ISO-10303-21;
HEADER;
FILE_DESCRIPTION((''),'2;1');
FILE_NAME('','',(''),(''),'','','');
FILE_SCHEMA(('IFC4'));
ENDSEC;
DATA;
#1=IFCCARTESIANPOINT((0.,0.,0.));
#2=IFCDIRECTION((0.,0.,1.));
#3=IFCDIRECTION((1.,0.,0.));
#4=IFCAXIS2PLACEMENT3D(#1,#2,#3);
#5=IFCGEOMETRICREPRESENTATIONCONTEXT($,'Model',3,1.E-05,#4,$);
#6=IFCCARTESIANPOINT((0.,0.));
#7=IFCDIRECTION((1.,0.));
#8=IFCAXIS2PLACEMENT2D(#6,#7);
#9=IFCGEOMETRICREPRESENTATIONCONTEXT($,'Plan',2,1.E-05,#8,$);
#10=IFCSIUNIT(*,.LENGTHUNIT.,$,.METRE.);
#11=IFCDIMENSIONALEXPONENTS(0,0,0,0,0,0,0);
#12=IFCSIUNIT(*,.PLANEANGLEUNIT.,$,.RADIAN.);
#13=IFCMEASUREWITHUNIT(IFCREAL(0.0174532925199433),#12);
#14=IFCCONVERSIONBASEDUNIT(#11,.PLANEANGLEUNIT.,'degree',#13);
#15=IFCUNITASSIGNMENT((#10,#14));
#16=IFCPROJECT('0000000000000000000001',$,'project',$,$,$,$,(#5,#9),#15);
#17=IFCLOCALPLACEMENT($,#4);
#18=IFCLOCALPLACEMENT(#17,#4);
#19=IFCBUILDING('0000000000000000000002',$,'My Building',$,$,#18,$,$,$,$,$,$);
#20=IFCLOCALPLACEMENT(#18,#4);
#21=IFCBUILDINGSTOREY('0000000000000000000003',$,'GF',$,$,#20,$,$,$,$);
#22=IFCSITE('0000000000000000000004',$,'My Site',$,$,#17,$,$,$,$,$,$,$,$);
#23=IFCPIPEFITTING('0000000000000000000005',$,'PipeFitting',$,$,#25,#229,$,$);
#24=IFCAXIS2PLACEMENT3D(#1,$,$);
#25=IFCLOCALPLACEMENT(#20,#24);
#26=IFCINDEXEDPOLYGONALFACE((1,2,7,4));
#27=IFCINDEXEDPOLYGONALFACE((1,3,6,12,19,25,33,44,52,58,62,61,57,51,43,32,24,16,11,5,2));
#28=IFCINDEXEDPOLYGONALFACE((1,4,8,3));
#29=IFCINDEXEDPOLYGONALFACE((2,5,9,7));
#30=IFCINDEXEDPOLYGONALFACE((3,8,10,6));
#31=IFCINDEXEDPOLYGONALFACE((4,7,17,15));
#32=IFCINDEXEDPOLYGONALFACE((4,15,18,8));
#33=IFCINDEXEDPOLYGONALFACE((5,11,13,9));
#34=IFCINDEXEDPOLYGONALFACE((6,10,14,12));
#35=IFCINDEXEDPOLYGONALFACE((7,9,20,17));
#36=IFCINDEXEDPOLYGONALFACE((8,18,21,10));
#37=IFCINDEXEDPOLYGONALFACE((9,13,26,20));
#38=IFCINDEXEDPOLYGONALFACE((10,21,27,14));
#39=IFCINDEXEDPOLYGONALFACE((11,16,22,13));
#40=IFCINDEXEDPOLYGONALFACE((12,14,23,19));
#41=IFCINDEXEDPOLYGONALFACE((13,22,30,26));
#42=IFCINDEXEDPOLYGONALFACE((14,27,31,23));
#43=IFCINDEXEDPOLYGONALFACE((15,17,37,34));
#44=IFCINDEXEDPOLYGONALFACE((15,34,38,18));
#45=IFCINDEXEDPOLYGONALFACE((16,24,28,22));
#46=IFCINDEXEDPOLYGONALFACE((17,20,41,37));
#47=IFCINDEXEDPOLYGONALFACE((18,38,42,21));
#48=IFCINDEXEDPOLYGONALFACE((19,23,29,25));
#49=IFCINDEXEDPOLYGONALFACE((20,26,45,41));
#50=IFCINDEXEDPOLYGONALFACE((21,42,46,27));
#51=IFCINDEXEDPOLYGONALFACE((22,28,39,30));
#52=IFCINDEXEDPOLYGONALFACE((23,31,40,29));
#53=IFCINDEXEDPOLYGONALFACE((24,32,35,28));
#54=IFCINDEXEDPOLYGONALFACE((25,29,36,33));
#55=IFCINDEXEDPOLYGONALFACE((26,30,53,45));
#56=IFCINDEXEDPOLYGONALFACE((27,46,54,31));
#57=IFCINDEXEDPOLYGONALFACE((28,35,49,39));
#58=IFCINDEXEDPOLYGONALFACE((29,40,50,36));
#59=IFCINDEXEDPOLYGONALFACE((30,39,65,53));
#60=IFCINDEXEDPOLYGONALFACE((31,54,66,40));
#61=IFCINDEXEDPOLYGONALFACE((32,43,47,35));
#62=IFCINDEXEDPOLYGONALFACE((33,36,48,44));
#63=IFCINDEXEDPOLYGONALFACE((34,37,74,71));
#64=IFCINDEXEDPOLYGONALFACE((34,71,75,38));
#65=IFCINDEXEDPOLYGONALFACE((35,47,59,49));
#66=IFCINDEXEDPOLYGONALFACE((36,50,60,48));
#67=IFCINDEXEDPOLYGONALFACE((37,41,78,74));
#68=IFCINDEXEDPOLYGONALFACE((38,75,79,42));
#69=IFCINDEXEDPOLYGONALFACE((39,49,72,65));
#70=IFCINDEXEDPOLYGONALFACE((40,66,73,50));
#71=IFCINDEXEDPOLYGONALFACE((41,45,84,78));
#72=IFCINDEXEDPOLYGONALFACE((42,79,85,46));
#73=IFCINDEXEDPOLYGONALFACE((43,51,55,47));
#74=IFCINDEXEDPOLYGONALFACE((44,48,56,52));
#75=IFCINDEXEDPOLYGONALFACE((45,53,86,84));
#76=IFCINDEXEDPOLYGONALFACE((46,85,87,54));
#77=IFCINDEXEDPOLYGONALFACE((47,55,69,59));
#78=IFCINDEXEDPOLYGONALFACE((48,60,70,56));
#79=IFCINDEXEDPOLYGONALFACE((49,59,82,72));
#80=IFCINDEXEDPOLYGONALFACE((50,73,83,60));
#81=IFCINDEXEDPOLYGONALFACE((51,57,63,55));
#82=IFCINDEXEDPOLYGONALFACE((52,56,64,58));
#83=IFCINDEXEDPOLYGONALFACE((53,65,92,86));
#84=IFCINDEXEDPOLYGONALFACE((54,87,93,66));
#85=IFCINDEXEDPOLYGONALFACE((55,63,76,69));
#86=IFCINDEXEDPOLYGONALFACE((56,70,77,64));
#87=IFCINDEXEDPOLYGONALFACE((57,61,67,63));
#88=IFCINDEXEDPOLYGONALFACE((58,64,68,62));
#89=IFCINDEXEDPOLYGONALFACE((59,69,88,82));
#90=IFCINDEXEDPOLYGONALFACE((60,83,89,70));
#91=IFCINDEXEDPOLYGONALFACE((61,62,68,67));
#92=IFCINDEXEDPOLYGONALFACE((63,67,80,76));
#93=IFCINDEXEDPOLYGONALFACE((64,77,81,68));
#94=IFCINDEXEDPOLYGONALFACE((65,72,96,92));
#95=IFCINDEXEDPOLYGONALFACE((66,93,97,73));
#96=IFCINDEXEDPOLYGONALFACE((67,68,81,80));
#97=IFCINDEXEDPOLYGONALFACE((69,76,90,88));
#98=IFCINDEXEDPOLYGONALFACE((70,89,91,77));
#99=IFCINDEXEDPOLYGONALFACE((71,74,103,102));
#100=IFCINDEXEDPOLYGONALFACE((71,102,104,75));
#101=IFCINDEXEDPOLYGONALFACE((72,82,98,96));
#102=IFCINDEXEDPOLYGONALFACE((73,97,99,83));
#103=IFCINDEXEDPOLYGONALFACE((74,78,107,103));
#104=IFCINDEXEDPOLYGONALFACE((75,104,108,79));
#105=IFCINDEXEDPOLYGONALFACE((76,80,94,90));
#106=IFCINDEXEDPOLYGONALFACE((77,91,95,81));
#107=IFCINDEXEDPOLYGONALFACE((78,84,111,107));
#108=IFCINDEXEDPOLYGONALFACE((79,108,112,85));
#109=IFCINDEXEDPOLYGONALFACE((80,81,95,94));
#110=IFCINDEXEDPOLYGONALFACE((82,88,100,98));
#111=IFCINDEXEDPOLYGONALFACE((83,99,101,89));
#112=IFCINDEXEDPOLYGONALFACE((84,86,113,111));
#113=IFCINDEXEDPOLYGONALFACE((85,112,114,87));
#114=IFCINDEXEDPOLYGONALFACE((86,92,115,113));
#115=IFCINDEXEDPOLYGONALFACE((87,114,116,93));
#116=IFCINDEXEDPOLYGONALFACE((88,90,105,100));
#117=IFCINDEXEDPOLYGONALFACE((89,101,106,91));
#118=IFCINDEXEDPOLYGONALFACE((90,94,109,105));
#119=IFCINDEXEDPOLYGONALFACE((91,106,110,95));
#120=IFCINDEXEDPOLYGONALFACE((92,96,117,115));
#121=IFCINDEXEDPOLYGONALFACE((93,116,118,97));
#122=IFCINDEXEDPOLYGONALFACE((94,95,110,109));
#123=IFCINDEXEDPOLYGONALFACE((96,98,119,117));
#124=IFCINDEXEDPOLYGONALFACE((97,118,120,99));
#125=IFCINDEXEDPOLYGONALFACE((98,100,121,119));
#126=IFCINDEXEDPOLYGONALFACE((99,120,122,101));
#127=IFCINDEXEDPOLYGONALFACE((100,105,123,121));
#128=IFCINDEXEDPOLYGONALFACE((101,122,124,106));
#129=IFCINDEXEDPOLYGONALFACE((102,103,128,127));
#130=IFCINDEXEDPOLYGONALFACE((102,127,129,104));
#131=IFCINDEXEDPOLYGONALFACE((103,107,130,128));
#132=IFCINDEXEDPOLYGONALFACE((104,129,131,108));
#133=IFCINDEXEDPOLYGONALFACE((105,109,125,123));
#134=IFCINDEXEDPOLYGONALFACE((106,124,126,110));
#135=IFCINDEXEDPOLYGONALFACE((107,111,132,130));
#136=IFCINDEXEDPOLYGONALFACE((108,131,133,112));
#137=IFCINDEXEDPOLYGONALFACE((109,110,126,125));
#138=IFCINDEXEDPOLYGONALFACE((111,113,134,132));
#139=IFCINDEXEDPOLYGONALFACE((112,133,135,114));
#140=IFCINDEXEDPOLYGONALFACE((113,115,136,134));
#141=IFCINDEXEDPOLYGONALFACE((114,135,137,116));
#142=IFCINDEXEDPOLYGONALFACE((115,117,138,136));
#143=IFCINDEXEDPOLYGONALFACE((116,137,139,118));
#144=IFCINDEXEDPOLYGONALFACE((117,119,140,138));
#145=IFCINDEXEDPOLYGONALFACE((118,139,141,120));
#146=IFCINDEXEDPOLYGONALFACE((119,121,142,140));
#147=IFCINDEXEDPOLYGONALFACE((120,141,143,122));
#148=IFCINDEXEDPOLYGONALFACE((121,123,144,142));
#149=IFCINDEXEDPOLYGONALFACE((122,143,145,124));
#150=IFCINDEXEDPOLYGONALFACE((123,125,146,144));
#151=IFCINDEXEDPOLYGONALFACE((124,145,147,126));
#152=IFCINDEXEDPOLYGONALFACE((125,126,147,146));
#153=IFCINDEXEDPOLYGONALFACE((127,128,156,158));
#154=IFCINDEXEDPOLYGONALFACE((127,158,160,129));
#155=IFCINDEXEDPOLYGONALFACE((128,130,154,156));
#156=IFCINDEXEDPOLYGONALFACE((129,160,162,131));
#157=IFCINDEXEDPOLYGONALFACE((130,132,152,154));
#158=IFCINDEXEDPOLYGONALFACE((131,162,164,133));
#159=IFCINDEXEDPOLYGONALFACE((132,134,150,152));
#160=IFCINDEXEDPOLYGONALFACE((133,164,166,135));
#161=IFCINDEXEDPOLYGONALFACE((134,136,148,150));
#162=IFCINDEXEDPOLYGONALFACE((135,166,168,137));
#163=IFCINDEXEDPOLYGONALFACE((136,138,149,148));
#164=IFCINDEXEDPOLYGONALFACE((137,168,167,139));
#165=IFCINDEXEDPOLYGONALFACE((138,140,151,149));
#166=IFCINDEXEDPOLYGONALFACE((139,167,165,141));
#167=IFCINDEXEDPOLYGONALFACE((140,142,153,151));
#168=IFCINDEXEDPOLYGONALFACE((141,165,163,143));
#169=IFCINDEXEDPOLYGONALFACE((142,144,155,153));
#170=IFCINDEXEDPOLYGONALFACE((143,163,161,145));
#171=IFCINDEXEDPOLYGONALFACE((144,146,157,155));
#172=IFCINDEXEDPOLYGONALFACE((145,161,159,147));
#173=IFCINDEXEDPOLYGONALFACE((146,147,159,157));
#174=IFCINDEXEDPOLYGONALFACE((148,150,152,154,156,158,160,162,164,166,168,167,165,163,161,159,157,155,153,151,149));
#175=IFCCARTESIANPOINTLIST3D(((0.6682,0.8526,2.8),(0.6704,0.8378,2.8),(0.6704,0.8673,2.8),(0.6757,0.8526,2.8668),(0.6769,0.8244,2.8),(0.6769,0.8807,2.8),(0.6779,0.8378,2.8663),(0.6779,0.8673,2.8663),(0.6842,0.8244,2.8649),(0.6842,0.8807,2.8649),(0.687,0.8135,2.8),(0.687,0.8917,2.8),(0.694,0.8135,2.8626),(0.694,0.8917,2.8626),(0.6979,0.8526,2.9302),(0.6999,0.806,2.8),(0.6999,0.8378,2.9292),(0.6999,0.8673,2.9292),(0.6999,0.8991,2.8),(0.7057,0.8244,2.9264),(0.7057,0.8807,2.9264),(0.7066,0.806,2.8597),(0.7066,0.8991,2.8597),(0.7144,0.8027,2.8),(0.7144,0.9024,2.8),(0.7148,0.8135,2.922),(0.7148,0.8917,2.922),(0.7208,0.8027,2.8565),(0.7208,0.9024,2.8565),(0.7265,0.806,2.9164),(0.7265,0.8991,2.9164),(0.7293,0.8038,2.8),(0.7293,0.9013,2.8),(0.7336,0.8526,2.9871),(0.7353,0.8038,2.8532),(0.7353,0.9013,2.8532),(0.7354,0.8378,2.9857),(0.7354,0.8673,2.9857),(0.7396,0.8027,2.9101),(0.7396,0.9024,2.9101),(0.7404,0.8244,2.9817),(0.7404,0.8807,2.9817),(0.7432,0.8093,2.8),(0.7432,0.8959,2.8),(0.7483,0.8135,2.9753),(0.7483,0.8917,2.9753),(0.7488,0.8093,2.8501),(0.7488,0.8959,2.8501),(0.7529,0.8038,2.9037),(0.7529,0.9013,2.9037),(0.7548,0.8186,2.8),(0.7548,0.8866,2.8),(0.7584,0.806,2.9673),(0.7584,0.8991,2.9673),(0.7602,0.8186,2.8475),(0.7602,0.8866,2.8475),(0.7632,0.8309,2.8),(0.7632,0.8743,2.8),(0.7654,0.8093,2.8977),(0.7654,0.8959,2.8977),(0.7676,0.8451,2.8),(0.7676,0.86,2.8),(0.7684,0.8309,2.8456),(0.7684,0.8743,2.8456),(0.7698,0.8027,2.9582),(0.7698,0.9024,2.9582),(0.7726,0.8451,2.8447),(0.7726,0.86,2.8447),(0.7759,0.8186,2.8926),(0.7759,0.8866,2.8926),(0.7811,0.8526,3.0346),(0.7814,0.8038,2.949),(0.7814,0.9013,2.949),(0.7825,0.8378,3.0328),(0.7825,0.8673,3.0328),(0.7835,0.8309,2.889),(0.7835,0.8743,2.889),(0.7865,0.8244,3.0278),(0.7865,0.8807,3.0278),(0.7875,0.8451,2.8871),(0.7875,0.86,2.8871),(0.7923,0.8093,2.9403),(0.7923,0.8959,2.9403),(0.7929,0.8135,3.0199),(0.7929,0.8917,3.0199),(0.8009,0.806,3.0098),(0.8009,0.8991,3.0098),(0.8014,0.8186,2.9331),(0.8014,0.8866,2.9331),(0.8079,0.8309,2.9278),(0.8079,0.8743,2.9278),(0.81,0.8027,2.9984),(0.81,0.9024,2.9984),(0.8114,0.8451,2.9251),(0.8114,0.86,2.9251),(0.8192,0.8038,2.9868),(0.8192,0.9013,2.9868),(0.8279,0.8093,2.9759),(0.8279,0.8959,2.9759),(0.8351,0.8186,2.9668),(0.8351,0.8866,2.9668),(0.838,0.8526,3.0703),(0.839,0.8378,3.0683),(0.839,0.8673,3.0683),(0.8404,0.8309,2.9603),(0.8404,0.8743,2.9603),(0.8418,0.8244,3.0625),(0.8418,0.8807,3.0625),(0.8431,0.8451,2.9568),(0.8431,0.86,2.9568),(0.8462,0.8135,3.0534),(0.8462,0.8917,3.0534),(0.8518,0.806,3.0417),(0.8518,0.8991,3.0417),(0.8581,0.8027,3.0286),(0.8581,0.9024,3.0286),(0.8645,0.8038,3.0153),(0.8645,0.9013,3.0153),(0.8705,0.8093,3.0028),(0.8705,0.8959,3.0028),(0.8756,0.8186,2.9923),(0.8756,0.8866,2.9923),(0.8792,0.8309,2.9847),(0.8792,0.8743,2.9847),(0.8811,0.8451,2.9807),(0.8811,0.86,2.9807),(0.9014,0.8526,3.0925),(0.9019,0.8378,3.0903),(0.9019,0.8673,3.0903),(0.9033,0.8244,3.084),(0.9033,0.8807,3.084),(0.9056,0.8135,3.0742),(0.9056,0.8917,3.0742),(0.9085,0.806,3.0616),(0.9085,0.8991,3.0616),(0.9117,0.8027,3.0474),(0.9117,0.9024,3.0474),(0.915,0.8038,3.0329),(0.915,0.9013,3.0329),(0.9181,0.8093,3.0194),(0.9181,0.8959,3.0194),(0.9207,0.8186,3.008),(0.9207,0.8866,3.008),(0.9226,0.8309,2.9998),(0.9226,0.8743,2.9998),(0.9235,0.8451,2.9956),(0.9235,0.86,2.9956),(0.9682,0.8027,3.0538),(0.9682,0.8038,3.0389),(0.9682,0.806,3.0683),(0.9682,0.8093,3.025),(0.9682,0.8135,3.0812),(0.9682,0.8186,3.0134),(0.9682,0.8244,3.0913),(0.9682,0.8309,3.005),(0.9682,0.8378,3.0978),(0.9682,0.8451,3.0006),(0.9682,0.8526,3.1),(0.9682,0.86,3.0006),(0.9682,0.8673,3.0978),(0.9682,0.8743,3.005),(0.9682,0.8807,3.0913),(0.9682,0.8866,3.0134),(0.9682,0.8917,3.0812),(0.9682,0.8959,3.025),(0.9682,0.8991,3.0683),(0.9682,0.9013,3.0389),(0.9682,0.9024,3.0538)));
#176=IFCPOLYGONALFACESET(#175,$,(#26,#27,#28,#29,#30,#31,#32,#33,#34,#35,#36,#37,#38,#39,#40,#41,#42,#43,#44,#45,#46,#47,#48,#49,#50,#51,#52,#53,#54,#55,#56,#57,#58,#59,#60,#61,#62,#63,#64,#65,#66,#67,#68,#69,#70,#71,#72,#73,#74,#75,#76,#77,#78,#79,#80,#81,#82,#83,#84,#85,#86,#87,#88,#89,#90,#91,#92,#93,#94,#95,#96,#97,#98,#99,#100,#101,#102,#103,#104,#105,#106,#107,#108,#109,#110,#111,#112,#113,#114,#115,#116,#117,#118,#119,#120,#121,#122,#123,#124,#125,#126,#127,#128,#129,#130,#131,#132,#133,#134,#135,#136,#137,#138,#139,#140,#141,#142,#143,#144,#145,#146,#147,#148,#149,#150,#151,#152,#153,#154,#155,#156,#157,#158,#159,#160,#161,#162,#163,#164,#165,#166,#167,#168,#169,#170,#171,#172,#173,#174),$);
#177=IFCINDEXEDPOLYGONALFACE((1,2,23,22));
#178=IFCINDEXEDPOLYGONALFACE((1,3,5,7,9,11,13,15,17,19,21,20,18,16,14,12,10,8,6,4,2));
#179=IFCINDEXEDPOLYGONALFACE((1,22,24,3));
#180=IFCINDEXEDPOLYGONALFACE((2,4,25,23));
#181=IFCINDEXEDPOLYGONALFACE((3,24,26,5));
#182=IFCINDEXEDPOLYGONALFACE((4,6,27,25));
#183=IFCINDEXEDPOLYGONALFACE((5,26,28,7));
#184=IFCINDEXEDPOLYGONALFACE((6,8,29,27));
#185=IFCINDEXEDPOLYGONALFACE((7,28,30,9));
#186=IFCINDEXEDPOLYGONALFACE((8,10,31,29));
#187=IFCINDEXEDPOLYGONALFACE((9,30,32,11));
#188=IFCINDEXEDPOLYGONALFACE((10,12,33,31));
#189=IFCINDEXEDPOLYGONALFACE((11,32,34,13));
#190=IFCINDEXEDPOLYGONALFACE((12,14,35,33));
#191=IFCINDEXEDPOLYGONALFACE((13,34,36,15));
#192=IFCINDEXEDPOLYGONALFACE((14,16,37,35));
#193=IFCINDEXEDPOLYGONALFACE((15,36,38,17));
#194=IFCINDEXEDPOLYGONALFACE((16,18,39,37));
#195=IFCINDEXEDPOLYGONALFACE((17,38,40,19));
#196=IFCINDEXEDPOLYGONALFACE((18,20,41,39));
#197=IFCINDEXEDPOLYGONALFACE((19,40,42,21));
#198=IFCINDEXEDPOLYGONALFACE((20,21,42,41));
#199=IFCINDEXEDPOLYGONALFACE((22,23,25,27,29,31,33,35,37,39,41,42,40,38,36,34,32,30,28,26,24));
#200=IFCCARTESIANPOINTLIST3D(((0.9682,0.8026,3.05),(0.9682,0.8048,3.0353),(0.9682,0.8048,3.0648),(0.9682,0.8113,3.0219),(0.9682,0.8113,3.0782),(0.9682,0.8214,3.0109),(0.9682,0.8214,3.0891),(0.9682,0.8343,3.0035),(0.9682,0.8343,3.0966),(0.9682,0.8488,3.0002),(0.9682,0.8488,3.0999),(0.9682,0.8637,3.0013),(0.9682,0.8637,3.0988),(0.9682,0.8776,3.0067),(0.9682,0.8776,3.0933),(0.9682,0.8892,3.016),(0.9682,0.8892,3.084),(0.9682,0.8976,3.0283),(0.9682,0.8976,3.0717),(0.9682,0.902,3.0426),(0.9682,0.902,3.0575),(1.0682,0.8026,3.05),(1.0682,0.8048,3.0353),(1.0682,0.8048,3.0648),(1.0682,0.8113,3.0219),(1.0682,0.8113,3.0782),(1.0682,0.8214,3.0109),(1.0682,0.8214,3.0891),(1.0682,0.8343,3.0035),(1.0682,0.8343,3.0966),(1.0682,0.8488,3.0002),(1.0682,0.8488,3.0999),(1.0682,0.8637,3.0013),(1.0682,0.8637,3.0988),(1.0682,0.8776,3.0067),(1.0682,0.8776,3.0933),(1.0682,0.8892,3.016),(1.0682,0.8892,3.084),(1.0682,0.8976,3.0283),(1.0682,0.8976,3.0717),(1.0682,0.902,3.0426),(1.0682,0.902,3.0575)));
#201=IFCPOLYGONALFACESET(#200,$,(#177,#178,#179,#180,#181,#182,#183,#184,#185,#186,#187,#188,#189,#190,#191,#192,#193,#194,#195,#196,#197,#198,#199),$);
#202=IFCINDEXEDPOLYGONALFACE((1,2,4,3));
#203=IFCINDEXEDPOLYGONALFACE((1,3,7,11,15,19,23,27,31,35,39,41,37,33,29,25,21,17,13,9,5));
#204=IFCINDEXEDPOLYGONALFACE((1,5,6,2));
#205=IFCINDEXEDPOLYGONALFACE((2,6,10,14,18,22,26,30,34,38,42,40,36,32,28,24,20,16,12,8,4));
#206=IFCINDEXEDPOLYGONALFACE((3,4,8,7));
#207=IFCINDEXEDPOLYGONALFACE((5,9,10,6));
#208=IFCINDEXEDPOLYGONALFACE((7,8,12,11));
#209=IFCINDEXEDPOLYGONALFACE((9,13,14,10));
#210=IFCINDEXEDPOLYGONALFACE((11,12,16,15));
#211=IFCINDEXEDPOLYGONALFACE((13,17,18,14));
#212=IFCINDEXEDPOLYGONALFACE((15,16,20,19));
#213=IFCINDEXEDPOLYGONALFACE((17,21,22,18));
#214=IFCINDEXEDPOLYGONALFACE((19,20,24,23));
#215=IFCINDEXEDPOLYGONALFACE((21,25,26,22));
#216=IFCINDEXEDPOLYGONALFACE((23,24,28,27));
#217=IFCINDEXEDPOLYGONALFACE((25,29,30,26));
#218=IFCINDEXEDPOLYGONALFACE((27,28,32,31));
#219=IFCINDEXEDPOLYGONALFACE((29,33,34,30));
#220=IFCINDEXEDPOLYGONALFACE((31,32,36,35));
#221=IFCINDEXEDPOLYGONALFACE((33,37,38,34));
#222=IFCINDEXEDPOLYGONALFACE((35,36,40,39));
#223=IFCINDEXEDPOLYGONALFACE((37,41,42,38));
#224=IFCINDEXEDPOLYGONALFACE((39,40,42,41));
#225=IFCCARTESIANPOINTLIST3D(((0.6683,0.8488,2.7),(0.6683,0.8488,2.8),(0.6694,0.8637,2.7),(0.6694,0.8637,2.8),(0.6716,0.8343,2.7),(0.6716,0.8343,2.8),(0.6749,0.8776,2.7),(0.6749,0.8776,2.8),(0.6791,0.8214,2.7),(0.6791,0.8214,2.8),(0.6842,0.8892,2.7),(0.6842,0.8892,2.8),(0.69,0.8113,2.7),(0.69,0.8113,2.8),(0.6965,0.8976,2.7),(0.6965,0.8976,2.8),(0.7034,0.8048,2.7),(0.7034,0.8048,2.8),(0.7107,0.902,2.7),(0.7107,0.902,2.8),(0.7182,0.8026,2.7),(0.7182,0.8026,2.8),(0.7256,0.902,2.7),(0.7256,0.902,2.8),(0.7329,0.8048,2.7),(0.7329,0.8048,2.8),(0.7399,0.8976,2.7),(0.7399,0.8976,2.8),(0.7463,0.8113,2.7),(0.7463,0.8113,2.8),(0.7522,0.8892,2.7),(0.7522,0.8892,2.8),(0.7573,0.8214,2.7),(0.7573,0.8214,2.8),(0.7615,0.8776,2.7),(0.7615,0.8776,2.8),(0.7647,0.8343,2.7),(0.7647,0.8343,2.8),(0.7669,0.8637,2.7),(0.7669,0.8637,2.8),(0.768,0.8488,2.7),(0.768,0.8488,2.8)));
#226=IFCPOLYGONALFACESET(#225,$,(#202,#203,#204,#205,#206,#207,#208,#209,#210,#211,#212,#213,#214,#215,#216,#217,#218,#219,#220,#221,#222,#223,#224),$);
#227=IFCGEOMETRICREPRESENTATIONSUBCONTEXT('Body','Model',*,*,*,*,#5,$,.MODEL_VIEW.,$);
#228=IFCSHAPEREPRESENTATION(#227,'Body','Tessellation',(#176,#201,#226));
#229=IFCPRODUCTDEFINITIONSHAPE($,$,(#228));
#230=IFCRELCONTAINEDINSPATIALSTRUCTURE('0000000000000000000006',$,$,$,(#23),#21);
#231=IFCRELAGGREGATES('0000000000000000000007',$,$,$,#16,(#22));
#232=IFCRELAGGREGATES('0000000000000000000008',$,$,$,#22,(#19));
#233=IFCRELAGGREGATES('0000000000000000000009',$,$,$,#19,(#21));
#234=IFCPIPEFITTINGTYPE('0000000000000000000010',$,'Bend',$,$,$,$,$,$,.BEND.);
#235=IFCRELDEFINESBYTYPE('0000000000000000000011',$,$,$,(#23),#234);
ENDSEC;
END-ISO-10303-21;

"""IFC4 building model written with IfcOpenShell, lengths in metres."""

from ifc_helpers import new_model, entity, si_unit, converted_unit, frame, origin_with_axes, origin_2d_with_axis, place, context, subcontext, project, spatial, circle, extrude, source, transform, mapped, type_object, type_shapes, element, save


model = new_model("IFC4")

# Units and contexts
model_context = context("Model", 3, precision=1e-05, world=origin_with_axes())
plan_context = context("Plan", 2, precision=1e-05, world=origin_2d_with_axis())
body_context_1 = subcontext(model_context, "Body", "Model", "MODEL_VIEW")
ifc_project = project(units=[si_unit("LENGTHUNIT", "METRE"), converted_unit("PLANEANGLEUNIT", "degree", entity("IfcReal", 0.0174532925199433), si_unit("PLANEANGLEUNIT", "RADIAN"), dimensions=[0, 0, 0, 0, 0, 0, 0])], contexts=[model_context, plan_context])

# Site, building, storey
site_placement = place(None, origin_with_axes())
site = spatial("IfcSite", under=ifc_project, at=site_placement, Name="My Site")
building_placement = place(site_placement, origin_with_axes())
building = spatial("IfcBuilding", under=site, at=building_placement, Name="My Building")
storey_placement = place(building_placement, origin_with_axes())
storey = spatial("IfcBuildingStorey", under=building, at=storey_placement, Name="GF")

# Pipe fitting
pipe_fitting_type = type_object("IfcPipeFittingType", Name="Bend", PredefinedType="BEND")
shared_shape_1 = source(origin_with_axes(), body_context_1, "Body", "SolidModel", [
    entity("IfcSweptDiskSolid", entity("IfcIndexedPolyCurve", entity("IfcCartesianPointList3D", [[0.0, 0.0, 0.1], [0.0, -0.0732, 0.2768], [0.0, -0.25, 0.35]]), [entity("IfcArcIndex", [1, 2, 3])]), 0.05),
    extrude(circle(Radius=0.05), origin_with_axes(), (0.0, 0.0, 1.0), 0.1),
    extrude(circle(Radius=0.05), frame((0.0, -0.25, 0.35), z_axis=(0.0, -1.0, 0.0), x_axis=(1.0, 0.0, 0.0)), (0.0, 0.0, 1.0), 0.1),
])
type_shapes(pipe_fitting_type, [shared_shape_1])
for number, where, z_axis, x_axis, name in (
    (1, (1.0682, 0.8526, 3.05), (-1.0, 0.0, 0.0), (0.0, -1.0, 0.0), "PipeFitting"),
):
    element("IfcPipeFitting", number, at=place(storey_placement, frame(where, z_axis=z_axis, x_axis=x_axis)), inside=storey, type_object=pipe_fitting_type, Name=name, context=body_context_1, shape_type="MappedRepresentation", body=[
        mapped(shared_shape_1, transform((0.0, 0.0, 0.0), x_axis=(1.0, 0.0, 0.0), y_axis=(0.0, 1.0, 0.0), z_axis=(0.0, 0.0, 1.0), scale=1.0)),
    ])

save(model, "model.ifc")
